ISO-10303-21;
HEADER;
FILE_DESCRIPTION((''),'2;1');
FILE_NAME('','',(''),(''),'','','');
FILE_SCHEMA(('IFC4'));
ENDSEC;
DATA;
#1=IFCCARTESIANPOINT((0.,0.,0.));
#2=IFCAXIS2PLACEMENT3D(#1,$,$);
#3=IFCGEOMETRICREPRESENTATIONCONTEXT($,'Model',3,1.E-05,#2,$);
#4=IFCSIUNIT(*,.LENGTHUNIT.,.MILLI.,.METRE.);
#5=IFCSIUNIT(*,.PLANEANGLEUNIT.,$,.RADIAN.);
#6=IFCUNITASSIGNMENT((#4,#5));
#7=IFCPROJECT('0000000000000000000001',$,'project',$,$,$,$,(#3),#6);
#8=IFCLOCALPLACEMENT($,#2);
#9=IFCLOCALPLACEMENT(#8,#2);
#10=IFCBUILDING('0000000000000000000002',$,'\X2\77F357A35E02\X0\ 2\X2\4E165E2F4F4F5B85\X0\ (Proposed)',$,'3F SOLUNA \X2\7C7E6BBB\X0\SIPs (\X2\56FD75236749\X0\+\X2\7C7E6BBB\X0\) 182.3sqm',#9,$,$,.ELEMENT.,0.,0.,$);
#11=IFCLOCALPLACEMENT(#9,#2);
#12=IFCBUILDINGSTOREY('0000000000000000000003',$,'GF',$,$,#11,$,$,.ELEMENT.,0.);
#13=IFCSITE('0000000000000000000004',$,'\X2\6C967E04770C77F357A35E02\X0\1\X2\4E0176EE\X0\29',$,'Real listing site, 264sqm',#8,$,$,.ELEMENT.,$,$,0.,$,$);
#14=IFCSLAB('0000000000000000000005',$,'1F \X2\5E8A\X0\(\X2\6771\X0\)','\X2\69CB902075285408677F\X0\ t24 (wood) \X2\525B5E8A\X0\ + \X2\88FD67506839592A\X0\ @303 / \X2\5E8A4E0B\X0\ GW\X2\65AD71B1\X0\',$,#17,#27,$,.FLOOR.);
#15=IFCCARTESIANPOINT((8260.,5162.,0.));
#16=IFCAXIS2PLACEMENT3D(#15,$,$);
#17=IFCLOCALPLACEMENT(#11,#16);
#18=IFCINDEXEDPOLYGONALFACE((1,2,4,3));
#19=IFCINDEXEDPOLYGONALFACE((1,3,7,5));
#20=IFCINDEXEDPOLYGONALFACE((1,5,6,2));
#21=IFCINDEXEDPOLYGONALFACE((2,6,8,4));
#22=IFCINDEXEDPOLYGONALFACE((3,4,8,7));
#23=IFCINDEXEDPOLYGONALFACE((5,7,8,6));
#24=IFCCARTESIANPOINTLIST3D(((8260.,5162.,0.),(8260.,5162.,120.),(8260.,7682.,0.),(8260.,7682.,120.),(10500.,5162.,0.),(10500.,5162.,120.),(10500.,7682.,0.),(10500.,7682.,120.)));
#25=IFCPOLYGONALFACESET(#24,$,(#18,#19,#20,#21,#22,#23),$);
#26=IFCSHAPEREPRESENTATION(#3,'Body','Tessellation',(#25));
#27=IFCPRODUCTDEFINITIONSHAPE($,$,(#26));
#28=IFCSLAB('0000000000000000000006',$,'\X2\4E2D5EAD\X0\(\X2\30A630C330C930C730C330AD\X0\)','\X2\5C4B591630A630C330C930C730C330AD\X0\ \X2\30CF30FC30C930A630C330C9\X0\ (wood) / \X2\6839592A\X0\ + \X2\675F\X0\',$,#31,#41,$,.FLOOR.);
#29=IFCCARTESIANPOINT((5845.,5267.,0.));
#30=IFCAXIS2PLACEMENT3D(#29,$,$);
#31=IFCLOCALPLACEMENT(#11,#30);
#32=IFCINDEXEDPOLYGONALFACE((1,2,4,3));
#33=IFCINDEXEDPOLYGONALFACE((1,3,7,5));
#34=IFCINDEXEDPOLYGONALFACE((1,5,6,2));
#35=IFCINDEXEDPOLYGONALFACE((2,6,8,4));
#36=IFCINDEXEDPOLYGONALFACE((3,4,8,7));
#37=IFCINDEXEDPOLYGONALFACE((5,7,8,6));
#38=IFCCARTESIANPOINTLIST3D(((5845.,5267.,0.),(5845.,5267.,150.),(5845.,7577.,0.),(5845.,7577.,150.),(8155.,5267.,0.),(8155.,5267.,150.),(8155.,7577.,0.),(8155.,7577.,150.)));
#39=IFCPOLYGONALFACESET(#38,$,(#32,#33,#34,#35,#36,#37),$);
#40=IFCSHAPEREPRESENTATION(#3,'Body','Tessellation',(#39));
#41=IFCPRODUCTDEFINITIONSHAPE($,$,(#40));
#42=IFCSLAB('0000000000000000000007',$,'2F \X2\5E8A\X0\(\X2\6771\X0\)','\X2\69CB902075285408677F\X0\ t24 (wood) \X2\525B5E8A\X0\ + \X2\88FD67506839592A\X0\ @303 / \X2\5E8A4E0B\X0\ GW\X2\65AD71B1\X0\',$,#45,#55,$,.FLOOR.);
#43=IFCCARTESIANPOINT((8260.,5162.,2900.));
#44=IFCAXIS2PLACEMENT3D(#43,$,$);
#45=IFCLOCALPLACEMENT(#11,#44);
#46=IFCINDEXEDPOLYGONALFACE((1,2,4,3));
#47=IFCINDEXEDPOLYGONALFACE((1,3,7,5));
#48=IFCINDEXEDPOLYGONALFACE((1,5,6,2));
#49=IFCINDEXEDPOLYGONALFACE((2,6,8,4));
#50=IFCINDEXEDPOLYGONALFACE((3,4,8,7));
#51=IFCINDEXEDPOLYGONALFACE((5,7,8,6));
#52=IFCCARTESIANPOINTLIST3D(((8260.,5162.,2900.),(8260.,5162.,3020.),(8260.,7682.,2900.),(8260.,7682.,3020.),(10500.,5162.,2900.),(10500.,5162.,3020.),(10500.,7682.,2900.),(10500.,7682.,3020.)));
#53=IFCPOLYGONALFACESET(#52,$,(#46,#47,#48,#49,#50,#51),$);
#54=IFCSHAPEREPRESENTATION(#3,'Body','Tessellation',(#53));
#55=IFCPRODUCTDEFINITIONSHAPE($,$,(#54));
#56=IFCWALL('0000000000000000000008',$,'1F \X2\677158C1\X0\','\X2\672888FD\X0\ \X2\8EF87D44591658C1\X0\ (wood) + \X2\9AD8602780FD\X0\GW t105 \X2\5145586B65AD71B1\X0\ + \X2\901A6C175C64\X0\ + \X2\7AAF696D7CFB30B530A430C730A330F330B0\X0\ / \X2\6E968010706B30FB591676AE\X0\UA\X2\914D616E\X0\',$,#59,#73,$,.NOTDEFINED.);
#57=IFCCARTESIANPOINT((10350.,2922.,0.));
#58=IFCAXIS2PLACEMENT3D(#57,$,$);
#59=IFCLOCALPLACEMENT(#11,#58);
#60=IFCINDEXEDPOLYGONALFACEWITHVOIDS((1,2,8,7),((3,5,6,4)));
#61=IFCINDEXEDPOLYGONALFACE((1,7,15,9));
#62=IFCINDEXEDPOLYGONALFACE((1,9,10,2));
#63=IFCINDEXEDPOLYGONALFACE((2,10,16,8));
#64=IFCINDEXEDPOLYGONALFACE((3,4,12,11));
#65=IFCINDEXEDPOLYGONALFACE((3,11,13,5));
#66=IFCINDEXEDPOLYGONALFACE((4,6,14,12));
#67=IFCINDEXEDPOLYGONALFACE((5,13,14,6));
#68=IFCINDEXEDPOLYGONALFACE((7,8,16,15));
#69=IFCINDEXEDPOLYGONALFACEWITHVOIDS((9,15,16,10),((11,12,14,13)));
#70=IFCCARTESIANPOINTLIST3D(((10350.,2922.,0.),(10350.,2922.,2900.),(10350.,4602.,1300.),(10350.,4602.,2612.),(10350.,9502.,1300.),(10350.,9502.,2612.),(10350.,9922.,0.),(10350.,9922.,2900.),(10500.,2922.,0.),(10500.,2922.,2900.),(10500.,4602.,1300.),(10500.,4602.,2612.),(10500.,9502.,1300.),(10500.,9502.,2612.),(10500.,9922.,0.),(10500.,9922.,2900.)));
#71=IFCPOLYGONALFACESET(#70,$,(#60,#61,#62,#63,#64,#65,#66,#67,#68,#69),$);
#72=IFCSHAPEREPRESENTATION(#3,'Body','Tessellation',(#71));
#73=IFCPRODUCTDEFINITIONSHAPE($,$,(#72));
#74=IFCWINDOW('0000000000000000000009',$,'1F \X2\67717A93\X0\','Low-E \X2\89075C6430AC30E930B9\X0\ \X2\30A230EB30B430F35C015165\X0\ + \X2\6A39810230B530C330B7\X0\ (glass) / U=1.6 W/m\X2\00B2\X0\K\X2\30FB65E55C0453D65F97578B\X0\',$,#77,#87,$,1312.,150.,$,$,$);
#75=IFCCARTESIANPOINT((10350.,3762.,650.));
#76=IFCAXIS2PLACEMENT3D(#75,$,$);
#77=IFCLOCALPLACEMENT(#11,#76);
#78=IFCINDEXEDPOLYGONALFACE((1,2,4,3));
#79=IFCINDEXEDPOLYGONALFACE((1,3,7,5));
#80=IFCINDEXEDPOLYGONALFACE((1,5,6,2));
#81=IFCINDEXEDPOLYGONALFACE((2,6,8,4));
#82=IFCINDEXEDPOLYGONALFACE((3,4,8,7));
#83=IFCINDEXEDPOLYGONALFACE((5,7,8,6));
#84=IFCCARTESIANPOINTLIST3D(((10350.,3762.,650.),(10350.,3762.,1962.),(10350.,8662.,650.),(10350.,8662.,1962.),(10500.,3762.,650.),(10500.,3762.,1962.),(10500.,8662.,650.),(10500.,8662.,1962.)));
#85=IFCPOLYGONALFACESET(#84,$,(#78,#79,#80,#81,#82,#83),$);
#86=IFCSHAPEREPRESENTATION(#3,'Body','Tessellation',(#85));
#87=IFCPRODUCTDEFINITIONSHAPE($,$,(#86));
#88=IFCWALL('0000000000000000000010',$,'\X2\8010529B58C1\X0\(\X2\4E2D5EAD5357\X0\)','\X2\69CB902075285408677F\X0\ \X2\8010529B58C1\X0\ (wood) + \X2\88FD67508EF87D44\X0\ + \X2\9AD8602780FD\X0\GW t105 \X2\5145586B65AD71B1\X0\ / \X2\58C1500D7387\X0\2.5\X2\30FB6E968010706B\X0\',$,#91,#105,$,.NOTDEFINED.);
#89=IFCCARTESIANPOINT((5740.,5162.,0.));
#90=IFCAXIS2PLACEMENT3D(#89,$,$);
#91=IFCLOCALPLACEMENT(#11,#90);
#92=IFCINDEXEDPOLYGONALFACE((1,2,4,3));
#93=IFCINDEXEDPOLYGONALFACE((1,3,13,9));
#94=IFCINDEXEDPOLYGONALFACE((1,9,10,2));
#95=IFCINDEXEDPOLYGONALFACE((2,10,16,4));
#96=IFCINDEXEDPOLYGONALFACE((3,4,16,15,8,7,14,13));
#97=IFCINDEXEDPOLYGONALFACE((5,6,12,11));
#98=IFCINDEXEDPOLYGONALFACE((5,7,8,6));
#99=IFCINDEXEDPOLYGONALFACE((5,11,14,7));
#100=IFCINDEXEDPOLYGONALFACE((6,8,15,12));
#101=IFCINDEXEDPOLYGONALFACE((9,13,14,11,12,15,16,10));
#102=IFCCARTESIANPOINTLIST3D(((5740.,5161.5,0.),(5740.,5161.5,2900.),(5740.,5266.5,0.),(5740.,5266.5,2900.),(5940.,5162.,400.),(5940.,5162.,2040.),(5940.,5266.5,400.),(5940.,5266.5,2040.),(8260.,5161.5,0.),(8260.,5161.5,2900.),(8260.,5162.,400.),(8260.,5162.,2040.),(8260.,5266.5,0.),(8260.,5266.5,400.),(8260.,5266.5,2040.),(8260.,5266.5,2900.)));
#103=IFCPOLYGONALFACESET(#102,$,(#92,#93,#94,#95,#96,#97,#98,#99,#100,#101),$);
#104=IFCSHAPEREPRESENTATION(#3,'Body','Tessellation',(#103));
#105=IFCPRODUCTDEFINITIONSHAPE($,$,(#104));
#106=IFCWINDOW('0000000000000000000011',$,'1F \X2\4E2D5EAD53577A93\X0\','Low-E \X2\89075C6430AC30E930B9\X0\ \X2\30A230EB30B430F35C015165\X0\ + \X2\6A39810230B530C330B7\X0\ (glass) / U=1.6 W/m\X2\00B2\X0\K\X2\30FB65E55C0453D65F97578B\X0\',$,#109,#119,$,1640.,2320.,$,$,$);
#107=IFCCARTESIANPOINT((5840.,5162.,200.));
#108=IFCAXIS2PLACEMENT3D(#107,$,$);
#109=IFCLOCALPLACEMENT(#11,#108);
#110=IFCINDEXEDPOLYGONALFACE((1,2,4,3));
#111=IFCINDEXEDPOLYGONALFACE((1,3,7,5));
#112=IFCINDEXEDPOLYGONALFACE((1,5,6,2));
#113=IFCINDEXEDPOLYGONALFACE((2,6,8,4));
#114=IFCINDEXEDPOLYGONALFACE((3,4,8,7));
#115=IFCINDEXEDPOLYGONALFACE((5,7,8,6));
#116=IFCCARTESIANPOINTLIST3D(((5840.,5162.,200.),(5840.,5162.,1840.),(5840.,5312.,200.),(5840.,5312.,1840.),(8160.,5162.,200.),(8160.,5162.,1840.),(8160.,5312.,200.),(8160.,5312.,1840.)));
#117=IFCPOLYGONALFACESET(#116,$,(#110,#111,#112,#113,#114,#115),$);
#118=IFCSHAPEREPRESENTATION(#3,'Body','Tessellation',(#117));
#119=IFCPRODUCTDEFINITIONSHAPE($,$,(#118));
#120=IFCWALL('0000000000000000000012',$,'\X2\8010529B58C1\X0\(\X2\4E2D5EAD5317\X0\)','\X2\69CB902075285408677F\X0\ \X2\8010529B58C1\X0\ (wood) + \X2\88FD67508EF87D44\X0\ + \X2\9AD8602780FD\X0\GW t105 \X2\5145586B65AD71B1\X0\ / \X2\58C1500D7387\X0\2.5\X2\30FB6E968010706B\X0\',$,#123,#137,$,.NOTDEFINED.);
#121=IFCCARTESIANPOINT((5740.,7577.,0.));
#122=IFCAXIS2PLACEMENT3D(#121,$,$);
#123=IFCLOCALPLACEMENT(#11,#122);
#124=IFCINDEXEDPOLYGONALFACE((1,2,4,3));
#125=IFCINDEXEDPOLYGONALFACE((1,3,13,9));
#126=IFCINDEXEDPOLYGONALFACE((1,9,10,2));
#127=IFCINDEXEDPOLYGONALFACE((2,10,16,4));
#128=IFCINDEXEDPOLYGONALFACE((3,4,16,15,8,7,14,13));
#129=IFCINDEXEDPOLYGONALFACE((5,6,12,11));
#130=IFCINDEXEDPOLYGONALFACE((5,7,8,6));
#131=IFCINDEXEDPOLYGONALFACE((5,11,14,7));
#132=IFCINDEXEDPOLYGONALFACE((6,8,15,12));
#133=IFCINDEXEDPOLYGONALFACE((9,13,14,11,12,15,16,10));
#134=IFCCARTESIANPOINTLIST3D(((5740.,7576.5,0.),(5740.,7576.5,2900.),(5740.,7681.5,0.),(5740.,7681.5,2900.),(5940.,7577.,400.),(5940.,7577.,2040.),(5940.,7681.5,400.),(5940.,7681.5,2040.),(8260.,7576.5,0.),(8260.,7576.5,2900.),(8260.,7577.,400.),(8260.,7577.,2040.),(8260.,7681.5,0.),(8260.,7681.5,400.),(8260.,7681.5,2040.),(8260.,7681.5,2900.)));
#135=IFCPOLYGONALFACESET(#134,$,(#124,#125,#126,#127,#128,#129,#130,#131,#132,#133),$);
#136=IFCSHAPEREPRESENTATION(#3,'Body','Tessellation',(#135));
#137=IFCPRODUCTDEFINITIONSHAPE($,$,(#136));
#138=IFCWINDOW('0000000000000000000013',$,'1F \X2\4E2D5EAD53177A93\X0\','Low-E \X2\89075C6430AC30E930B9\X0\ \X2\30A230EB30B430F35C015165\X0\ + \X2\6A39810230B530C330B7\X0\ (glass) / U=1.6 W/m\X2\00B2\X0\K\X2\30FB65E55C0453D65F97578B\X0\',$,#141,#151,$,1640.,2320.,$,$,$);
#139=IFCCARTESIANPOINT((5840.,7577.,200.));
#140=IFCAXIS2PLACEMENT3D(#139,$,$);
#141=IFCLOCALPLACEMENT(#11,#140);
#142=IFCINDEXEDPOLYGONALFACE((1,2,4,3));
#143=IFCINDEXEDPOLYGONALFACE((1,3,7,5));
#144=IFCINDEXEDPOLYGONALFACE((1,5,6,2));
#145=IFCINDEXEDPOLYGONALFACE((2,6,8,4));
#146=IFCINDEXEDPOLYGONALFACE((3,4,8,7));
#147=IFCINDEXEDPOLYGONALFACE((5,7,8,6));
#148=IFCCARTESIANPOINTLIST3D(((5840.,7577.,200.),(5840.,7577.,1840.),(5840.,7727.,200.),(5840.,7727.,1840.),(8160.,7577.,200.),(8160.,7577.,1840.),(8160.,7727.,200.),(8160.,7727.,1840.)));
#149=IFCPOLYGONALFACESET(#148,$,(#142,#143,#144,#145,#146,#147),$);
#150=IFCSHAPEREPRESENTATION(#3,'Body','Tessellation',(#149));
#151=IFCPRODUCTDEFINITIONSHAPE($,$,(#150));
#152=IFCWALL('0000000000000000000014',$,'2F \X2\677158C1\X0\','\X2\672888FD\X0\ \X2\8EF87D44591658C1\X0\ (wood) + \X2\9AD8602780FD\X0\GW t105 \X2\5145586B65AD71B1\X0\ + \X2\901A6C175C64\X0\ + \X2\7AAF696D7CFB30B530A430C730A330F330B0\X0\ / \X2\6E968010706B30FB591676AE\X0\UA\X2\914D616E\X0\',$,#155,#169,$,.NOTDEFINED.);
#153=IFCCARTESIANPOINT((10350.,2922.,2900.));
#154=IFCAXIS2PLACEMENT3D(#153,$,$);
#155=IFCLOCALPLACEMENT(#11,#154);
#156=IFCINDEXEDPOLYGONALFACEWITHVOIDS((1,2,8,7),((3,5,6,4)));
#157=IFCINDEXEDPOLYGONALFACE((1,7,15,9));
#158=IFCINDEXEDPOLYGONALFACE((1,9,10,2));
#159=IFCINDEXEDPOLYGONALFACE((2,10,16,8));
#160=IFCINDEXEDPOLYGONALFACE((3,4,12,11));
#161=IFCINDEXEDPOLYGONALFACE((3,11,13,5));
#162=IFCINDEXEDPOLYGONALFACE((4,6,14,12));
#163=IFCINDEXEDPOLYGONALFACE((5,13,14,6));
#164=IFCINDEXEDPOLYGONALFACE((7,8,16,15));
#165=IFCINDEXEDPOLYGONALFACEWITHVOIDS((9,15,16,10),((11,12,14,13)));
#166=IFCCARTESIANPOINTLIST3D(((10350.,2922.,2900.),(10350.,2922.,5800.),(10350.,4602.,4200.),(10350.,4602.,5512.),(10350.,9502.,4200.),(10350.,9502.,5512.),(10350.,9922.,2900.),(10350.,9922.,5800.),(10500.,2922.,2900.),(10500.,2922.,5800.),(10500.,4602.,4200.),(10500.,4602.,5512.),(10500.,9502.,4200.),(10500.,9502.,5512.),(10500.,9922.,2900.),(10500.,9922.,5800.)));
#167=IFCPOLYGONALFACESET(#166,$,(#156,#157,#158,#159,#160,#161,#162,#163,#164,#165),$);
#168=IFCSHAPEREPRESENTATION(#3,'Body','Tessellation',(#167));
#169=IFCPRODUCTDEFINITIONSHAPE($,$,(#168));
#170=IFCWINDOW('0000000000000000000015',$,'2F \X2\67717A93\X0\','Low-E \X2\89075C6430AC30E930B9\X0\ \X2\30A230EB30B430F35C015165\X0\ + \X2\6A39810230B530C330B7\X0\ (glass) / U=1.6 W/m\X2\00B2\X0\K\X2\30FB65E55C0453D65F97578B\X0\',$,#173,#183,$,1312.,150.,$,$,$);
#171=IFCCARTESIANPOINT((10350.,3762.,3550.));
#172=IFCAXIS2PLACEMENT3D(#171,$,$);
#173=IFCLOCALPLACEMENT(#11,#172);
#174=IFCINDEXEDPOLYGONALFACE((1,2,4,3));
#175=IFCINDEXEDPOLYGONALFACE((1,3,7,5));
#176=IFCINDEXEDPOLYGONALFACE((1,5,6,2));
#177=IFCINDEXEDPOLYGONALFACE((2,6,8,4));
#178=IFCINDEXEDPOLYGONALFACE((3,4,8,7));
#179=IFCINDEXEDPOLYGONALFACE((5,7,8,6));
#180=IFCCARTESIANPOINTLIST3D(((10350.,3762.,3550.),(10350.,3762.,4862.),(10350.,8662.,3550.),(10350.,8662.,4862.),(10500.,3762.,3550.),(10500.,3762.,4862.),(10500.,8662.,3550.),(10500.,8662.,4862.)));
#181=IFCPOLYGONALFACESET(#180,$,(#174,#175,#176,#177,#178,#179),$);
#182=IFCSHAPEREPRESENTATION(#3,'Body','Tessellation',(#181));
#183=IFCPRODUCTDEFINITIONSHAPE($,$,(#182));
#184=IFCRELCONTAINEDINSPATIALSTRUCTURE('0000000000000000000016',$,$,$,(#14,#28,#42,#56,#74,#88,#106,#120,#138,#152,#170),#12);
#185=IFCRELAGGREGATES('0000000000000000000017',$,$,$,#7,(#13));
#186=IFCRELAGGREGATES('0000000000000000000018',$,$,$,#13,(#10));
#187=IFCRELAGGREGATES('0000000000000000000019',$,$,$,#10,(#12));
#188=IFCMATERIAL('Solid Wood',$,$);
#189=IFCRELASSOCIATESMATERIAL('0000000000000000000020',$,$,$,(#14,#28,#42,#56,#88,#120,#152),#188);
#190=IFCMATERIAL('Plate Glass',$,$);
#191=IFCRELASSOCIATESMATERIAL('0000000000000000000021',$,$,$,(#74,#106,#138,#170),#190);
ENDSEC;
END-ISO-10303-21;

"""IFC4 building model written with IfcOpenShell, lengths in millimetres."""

from ifc_helpers import new_model, si_unit, frame, frame_2d, origin, place, context, project, spatial, rectangle, extrude, material, element, fill, save


model = new_model("IFC4")

# Units and contexts
model_context = context("Model", 3, precision=1e-05, world=origin())
ifc_project = project(units=[si_unit("LENGTHUNIT", "METRE", prefix="MILLI"), si_unit("PLANEANGLEUNIT", "RADIAN")], contexts=[model_context])

# Site, building, storey
site_placement = place(None, origin())
site = spatial("IfcSite", under=ifc_project, at=site_placement, Name="沖縄県石垣市1丁目29", ObjectType="Real listing site, 264sqm", CompositionType="ELEMENT", RefElevation=0.0)
building_placement = place(site_placement, origin())
building = spatial("IfcBuilding", under=site, at=building_placement, Name="石垣市 2世帯住宅 (Proposed)", ObjectType="3F SOLUNA 籾殻SIPs (国産杉+籾殻) 182.3sqm", CompositionType="ELEMENT", ElevationOfRefHeight=0.0, ElevationOfTerrain=0.0)
storey_placement = place(building_placement, origin())
storey = spatial("IfcBuildingStorey", under=building, at=storey_placement, Name="GF", CompositionType="ELEMENT", Elevation=0.0)

# Slabs
ifc_material_1 = material(Name="Solid Wood")
slab_1_placement = place(storey_placement, frame((8260.0, 5162.0, 0.0)))
element("IfcSlab", 1, at=slab_1_placement, inside=storey, material=ifc_material_1, Name="1F 床(東)", Description="構造用合板 t24 (wood) 剛床 + 製材根太 @303 / 床下 GW断熱", PredefinedType="FLOOR", context=model_context, shape_type="SweptSolid", body=[
    extrude(rectangle(XDim=2240.0, YDim=2520.0, at=frame_2d((1120.0, 1260.0))), frame((8260.0, 5162.0, 0.0)), (0.0, 0.0, 1.0), 120.0),
])
slab_2_placement = place(storey_placement, frame((5845.0, 5267.0, 0.0)))
element("IfcSlab", 2, at=slab_2_placement, inside=storey, material=ifc_material_1, Name="中庭(ウッドデッキ)", Description="屋外ウッドデッキ ハードウッド (wood) / 根太 + 束", PredefinedType="FLOOR", context=model_context, shape_type="SweptSolid", body=[
    extrude(rectangle(XDim=2310.0, YDim=2310.0, at=frame_2d((1155.0, 1155.0))), frame((5845.0, 5267.0, 0.0)), (0.0, 0.0, 1.0), 150.0),
])
slab_3_placement = place(storey_placement, frame((8260.0, 5162.0, 2900.0)))
element("IfcSlab", 3, at=slab_3_placement, inside=storey, material=ifc_material_1, Name="2F 床(東)", Description="構造用合板 t24 (wood) 剛床 + 製材根太 @303 / 床下 GW断熱", PredefinedType="FLOOR", context=model_context, shape_type="SweptSolid", body=[
    extrude(rectangle(XDim=2240.0, YDim=2520.0, at=frame_2d((1120.0, 1260.0))), frame((8260.0, 5162.0, 2900.0)), (0.0, 0.0, 1.0), 120.0),
])

# Walls, openings, windows
wall_1_placement = place(storey_placement, frame((10350.0, 2922.0, 0.0)))
wall_1 = element("IfcWall", 4, at=wall_1_placement, inside=storey, material=ifc_material_1, Name="1F 東壁", Description="木製 軸組外壁 (wood) + 高性能GW t105 充填断熱 + 通気層 + 窯業系サイディング / 準耐火・外皮UA配慮", PredefinedType="NOTDEFINED", context=model_context, shape_type="SweptSolid", body=[
    extrude(rectangle(XDim=150.0, YDim=7000.0, at=frame_2d((75.0, 3500.0))), frame((10350.0, 2922.0, 0.0)), (0.0, 0.0, 1.0), 2900.0),
])
opening_1_placement = place(storey_placement, frame((10350.0, 3762.0, 650.0)))
opening_1 = element("IfcOpeningElement", 5, at=opening_1_placement, cuts=wall_1, PredefinedType="NOTDEFINED", context=model_context, shape_type="SweptSolid", body=[
    extrude(rectangle(XDim=150.0, YDim=4900.0, at=frame_2d((75.0, 2450.0))), frame((10350.0, 3762.0, 650.0)), (0.0, 0.0, 1.0), 1312.0),
])
ifc_material_2 = material(Name="Plate Glass")
window_1_placement = place(storey_placement, frame((10350.0, 3762.0, 650.0)))
window_1 = element("IfcWindow", 6, at=window_1_placement, inside=storey, material=ifc_material_2, Name="1F 東窓", Description="Low-E 複層ガラス アルゴン封入 + 樹脂サッシ (glass) / U=1.6 W/m²K・日射取得型", OverallHeight=1312.0, OverallWidth=150.0, context=model_context, shape_type="SweptSolid", body=[
    extrude(rectangle(XDim=150.0, YDim=4900.0, at=frame_2d((75.0, 2450.0))), frame((10350.0, 3762.0, 650.0)), (0.0, 0.0, 1.0), 1312.0),
])
fill(opening_1, window_1)
wall_2_placement = place(storey_placement, frame((5740.0, 5162.0, 0.0)))
wall_2 = element("IfcWall", 7, at=wall_2_placement, inside=storey, material=ifc_material_1, Name="耐力壁(中庭南)", Description="構造用合板 耐力壁 (wood) + 製材軸組 + 高性能GW t105 充填断熱 / 壁倍率2.5・準耐火", PredefinedType="NOTDEFINED", context=model_context, shape_type="SweptSolid", body=[
    extrude(rectangle(XDim=2520.0, YDim=105.0, at=frame_2d((1260.0, 52.0))), frame((5740.0, 5162.0, 0.0)), (0.0, 0.0, 1.0), 2900.0),
])
opening_2_placement = place(storey_placement, frame((5840.0, 5162.0, 200.0)))
opening_2 = element("IfcOpeningElement", 8, at=opening_2_placement, cuts=wall_2, PredefinedType="NOTDEFINED", context=model_context, shape_type="SweptSolid", body=[
    extrude(rectangle(XDim=2320.0, YDim=150.0, at=frame_2d((1160.0, 75.0))), frame((5840.0, 5162.0, 200.0)), (0.0, 0.0, 1.0), 1640.0),
])
window_2_placement = place(storey_placement, frame((5840.0, 5162.0, 200.0)))
window_2 = element("IfcWindow", 9, at=window_2_placement, inside=storey, material=ifc_material_2, Name="1F 中庭南窓", Description="Low-E 複層ガラス アルゴン封入 + 樹脂サッシ (glass) / U=1.6 W/m²K・日射取得型", OverallHeight=1640.0, OverallWidth=2320.0, context=model_context, shape_type="SweptSolid", body=[
    extrude(rectangle(XDim=2320.0, YDim=150.0, at=frame_2d((1160.0, 75.0))), frame((5840.0, 5162.0, 200.0)), (0.0, 0.0, 1.0), 1640.0),
])
fill(opening_2, window_2)
wall_3_placement = place(storey_placement, frame((5740.0, 7577.0, 0.0)))
wall_3 = element("IfcWall", 10, at=wall_3_placement, inside=storey, material=ifc_material_1, Name="耐力壁(中庭北)", Description="構造用合板 耐力壁 (wood) + 製材軸組 + 高性能GW t105 充填断熱 / 壁倍率2.5・準耐火", PredefinedType="NOTDEFINED", context=model_context, shape_type="SweptSolid", body=[
    extrude(rectangle(XDim=2520.0, YDim=105.0, at=frame_2d((1260.0, 52.0))), frame((5740.0, 7577.0, 0.0)), (0.0, 0.0, 1.0), 2900.0),
])
opening_3_placement = place(storey_placement, frame((5840.0, 7577.0, 200.0)))
opening_3 = element("IfcOpeningElement", 11, at=opening_3_placement, cuts=wall_3, PredefinedType="NOTDEFINED", context=model_context, shape_type="SweptSolid", body=[
    extrude(rectangle(XDim=2320.0, YDim=150.0, at=frame_2d((1160.0, 75.0))), frame((5840.0, 7577.0, 200.0)), (0.0, 0.0, 1.0), 1640.0),
])
window_3_placement = place(storey_placement, frame((5840.0, 7577.0, 200.0)))
window_3 = element("IfcWindow", 12, at=window_3_placement, inside=storey, material=ifc_material_2, Name="1F 中庭北窓", Description="Low-E 複層ガラス アルゴン封入 + 樹脂サッシ (glass) / U=1.6 W/m²K・日射取得型", OverallHeight=1640.0, OverallWidth=2320.0, context=model_context, shape_type="SweptSolid", body=[
    extrude(rectangle(XDim=2320.0, YDim=150.0, at=frame_2d((1160.0, 75.0))), frame((5840.0, 7577.0, 200.0)), (0.0, 0.0, 1.0), 1640.0),
])
fill(opening_3, window_3)

# Wall, opening, window
wall_4_placement = place(storey_placement, frame((10350.0, 2922.0, 2900.0)))
wall_4 = element("IfcWall", 13, at=wall_4_placement, inside=storey, material=ifc_material_1, Name="2F 東壁", Description="木製 軸組外壁 (wood) + 高性能GW t105 充填断熱 + 通気層 + 窯業系サイディング / 準耐火・外皮UA配慮", PredefinedType="NOTDEFINED", context=model_context, shape_type="SweptSolid", body=[
    extrude(rectangle(XDim=150.0, YDim=7000.0, at=frame_2d((75.0, 3500.0))), frame((10350.0, 2922.0, 2900.0)), (0.0, 0.0, 1.0), 2900.0),
])
opening_4_placement = place(storey_placement, frame((10350.0, 3762.0, 3550.0)))
opening_4 = element("IfcOpeningElement", 14, at=opening_4_placement, cuts=wall_4, PredefinedType="NOTDEFINED", context=model_context, shape_type="SweptSolid", body=[
    extrude(rectangle(XDim=150.0, YDim=4900.0, at=frame_2d((75.0, 2450.0))), frame((10350.0, 3762.0, 3550.0)), (0.0, 0.0, 1.0), 1312.0),
])
window_4_placement = place(storey_placement, frame((10350.0, 3762.0, 3550.0)))
window_4 = element("IfcWindow", 15, at=window_4_placement, inside=storey, material=ifc_material_2, Name="2F 東窓", Description="Low-E 複層ガラス アルゴン封入 + 樹脂サッシ (glass) / U=1.6 W/m²K・日射取得型", OverallHeight=1312.0, OverallWidth=150.0, context=model_context, shape_type="SweptSolid", body=[
    extrude(rectangle(XDim=150.0, YDim=4900.0, at=frame_2d((75.0, 2450.0))), frame((10350.0, 3762.0, 3550.0)), (0.0, 0.0, 1.0), 1312.0),
])
fill(opening_4, window_4)

save(model, "model.ifc")
